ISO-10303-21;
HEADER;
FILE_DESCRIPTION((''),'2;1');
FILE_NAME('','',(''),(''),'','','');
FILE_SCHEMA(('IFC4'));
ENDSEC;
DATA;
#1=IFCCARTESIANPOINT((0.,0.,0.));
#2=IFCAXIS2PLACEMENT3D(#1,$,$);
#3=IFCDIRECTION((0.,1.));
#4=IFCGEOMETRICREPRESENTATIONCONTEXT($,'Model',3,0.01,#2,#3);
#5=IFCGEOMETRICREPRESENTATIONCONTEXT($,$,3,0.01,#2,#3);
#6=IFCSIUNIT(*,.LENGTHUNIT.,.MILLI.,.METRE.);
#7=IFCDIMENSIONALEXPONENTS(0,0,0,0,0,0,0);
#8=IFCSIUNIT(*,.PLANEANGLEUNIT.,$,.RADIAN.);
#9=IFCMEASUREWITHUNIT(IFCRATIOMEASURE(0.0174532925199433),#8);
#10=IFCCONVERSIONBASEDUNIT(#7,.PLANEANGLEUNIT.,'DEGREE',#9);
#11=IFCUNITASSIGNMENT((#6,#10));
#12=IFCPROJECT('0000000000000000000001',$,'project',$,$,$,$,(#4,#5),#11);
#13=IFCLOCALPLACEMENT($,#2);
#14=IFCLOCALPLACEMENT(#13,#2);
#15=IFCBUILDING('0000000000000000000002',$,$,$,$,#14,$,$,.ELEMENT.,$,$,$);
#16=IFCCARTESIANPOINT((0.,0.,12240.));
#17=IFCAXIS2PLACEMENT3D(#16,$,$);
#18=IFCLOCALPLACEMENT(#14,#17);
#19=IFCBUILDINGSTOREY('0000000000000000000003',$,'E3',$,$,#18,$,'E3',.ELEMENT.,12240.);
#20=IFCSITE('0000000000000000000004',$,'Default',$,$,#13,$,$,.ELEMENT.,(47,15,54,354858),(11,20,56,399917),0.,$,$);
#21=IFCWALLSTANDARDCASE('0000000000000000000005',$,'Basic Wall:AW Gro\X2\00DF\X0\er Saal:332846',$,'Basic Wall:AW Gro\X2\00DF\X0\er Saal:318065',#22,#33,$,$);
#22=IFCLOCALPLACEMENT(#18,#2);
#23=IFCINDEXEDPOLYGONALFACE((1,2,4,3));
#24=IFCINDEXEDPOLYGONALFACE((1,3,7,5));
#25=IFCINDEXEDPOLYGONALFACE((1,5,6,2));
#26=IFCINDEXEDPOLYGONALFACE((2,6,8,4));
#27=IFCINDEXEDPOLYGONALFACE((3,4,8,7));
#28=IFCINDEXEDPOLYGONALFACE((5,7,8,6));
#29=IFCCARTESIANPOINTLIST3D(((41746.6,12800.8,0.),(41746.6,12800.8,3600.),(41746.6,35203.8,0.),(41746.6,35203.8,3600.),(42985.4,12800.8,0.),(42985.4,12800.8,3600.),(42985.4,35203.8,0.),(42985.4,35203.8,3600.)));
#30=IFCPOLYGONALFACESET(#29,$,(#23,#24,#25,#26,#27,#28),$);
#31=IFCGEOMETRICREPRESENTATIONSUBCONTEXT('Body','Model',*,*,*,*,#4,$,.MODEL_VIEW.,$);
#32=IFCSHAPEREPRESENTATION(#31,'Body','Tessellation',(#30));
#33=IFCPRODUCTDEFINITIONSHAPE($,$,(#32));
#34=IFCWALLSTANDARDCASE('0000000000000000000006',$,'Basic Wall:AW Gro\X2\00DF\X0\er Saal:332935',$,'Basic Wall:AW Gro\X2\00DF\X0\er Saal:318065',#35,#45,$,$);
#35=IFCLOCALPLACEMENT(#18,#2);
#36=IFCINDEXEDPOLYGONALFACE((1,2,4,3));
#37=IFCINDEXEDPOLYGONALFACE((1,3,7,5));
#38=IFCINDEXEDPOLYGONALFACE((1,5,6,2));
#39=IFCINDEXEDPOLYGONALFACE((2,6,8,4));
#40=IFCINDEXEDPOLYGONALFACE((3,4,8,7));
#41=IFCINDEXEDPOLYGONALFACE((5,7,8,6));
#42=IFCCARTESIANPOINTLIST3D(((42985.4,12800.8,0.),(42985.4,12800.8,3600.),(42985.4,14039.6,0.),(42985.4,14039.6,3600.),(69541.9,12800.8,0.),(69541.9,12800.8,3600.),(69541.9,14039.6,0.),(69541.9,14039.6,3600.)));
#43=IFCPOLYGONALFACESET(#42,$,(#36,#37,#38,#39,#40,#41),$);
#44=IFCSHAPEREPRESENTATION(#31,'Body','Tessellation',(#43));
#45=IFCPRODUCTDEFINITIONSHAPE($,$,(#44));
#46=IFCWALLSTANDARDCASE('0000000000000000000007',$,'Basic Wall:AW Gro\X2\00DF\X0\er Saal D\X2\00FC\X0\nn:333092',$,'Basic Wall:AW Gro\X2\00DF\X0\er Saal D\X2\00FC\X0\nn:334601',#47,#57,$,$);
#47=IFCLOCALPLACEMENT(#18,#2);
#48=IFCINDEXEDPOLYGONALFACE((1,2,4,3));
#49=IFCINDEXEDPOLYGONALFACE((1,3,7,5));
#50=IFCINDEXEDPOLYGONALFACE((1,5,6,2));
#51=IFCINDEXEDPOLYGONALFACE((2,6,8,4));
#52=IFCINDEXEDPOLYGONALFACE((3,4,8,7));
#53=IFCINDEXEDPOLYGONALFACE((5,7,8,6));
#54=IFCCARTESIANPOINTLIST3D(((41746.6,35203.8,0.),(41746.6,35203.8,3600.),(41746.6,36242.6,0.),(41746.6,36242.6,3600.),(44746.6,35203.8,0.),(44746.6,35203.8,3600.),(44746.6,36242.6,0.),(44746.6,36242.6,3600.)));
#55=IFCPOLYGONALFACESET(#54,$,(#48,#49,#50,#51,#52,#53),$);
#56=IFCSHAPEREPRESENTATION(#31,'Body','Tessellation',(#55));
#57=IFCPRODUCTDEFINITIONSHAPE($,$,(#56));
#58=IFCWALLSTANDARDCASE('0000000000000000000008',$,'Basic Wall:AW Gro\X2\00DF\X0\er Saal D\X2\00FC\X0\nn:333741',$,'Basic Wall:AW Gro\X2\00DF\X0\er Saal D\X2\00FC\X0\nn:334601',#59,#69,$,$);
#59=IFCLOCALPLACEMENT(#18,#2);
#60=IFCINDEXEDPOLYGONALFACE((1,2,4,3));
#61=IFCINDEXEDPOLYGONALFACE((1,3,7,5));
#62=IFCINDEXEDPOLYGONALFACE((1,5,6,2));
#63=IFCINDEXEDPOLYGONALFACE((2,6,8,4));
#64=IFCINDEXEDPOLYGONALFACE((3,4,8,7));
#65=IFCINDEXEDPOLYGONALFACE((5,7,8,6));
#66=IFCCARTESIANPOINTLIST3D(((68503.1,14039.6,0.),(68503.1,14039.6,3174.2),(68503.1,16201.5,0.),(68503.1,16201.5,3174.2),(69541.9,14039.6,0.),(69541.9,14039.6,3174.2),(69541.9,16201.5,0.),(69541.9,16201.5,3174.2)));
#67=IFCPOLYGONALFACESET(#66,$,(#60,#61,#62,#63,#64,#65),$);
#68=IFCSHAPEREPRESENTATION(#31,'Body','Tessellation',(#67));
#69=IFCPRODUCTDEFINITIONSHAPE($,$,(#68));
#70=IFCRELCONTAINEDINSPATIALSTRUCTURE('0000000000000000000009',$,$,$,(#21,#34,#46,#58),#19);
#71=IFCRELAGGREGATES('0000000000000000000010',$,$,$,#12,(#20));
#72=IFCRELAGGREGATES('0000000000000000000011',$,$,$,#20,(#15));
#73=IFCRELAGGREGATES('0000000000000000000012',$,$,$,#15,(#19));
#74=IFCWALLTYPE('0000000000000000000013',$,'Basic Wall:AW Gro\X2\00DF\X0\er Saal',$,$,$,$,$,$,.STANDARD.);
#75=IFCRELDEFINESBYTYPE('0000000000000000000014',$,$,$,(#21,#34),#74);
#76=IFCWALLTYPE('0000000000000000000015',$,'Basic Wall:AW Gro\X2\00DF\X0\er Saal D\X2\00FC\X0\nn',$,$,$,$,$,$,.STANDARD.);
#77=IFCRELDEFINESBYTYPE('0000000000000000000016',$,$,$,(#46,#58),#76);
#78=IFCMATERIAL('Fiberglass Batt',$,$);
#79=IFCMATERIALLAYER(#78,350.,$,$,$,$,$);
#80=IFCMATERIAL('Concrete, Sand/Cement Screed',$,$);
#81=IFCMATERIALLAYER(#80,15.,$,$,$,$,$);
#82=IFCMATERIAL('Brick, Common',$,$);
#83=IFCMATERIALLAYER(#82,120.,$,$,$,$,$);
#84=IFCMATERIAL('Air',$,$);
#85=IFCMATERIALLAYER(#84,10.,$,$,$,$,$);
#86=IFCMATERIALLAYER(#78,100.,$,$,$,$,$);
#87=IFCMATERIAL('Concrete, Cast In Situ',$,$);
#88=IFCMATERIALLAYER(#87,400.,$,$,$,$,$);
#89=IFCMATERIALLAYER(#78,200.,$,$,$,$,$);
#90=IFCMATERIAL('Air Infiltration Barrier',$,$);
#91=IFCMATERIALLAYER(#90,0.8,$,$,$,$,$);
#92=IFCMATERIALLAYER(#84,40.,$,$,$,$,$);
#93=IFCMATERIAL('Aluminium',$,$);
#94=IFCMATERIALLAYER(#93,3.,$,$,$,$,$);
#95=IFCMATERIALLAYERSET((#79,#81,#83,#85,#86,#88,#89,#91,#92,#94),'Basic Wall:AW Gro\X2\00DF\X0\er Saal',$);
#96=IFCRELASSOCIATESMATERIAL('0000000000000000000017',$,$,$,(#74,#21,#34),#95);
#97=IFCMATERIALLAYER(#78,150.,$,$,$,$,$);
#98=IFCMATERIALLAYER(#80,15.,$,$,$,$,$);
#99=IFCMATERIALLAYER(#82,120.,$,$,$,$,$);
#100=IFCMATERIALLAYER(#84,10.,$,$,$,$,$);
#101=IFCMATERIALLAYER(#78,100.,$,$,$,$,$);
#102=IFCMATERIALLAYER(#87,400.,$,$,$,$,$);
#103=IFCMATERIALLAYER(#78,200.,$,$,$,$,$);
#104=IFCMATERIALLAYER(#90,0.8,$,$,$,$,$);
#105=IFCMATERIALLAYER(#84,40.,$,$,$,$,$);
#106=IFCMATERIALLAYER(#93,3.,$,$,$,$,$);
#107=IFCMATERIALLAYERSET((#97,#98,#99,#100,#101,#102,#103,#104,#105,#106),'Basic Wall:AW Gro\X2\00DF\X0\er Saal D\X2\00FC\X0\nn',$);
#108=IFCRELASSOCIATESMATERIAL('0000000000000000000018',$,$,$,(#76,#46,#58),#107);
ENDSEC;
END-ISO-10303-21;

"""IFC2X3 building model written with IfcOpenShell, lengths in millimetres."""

from ifc_helpers import new_model, entity, si_unit, converted_unit, direction, frame, frame_2d, origin, place, context, subcontext, project, spatial, polyline, rectangle, extrude, clip, bounded_halfspace, material, layer, layer_set, layer_usage, type_object, element, save


model = new_model("IFC2X3")

# Units and contexts
model_context = context("Model", 3, precision=0.01, world=origin(), true_north=direction((0.0, 1.0)))
context_of_model = context(None, 3, precision=0.01, world=origin(), true_north=direction((0.0, 1.0)))
body_context = subcontext(model_context, "Body", "Model", "MODEL_VIEW")
ifc_project = project(units=[si_unit("LENGTHUNIT", "METRE", prefix="MILLI"), converted_unit("PLANEANGLEUNIT", "DEGREE", entity("IfcRatioMeasure", 0.0174532925199433), si_unit("PLANEANGLEUNIT", "RADIAN"), dimensions=[0, 0, 0, 0, 0, 0, 0])], contexts=[model_context, context_of_model])

# Site, building, storey
site_placement = place(None, origin())
site = spatial("IfcSite", under=ifc_project, at=site_placement, Name="Default", CompositionType="ELEMENT", RefLatitude=(47, 15, 54, 354858), RefLongitude=(11, 20, 56, 399917), RefElevation=0.0)
building_placement = place(site_placement, origin())
building = spatial("IfcBuilding", under=site, at=building_placement, CompositionType="ELEMENT")
storey_placement = place(building_placement, frame((0.0, 0.0, 12240.0)))
storey = spatial("IfcBuildingStorey", under=building, at=storey_placement, Name="E3", LongName="E3", CompositionType="ELEMENT", Elevation=12240.0)

# Shared definitions
ifc_material_1 = material(Name="Concrete, Sand/Cement Screed")
ifc_material_2 = material(Name="Air Infiltration Barrier")
ifc_material_3 = material(Name="Fiberglass Batt")

# Shared definitions
ifc_material_4 = material(Name="Concrete, Cast In Situ")

# Shared definitions
ifc_material_5 = material(Name="Air")
ifc_material_6 = material(Name="Aluminium")

# Walls
ifc_material_7 = material(Name="Brick, Common")
ifc_layer_1 = layer(ifc_material_3, 350.0)
ifc_layer_2 = layer(ifc_material_1, 15.0)
ifc_layer_3 = layer(ifc_material_7, 120.0)
ifc_layer_4 = layer(ifc_material_5, 10.0)
ifc_layer_5 = layer(ifc_material_3, 100.0)
ifc_layer_6 = layer(ifc_material_4, 400.0)
ifc_layer_7 = layer(ifc_material_3, 200.0)
ifc_layer_8 = layer(ifc_material_2, 0.8)
ifc_layer_9 = layer(ifc_material_5, 40.0)
ifc_layer_10 = layer(ifc_material_6, 3.0)
ifc_layer_set_1 = layer_set([ifc_layer_1, ifc_layer_2, ifc_layer_3, ifc_layer_4, ifc_layer_5, ifc_layer_6, ifc_layer_7, ifc_layer_8, ifc_layer_9, ifc_layer_10], Name="Basic Wall:AW Großer Saal")
ifc_layer_usage_1 = layer_usage(ifc_layer_set_1, "AXIS2", "NEGATIVE", 619.4)
wall_type_1 = type_object("IfcWallType", Name="Basic Wall:AW Großer Saal", PredefinedType="STANDARD", material=ifc_layer_set_1)
wall_1_placement = place(storey_placement, frame((42366.0, 35203.8, 0.0), z_axis=(0.0, 0.0, 1.0), x_axis=(0.0, -1.0, 0.0)))
element("IfcWallStandardCase", 1, at=wall_1_placement, inside=storey, type_object=wall_type_1, material=ifc_layer_usage_1, Name="Basic Wall:AW Großer Saal:332846", ObjectType="Basic Wall:AW Großer Saal:318065", context=body_context, shape_type="SweptSolid", body=[
    extrude(rectangle(XDim=22402.9, YDim=1238.8, at=frame_2d((11201.5, 0.0), x_axis=(-1.0, 0.0))), origin(), (0.0, 0.0, 1.0), 3600.0),
])
ifc_layer_usage_2 = layer_usage(ifc_layer_set_1, "AXIS2", "NEGATIVE", 619.4)
wall_2_placement = place(storey_placement, frame((42985.4, 13420.2, 0.0)))
element("IfcWallStandardCase", 2, at=wall_2_placement, inside=storey, type_object=wall_type_1, material=ifc_layer_usage_2, Name="Basic Wall:AW Großer Saal:332935", ObjectType="Basic Wall:AW Großer Saal:318065", context=body_context, shape_type="SweptSolid", body=[
    extrude(rectangle(XDim=26556.5, YDim=1238.8, at=frame_2d((13278.3, 0.0), x_axis=(-1.0, 0.0))), origin(), (0.0, 0.0, 1.0), 3600.0),
])
ifc_layer_11 = layer(ifc_material_3, 150.0)
ifc_layer_12 = layer(ifc_material_1, 15.0)
ifc_layer_13 = layer(ifc_material_7, 120.0)
ifc_layer_14 = layer(ifc_material_5, 10.0)
ifc_layer_15 = layer(ifc_material_3, 100.0)
ifc_layer_16 = layer(ifc_material_4, 400.0)
ifc_layer_17 = layer(ifc_material_3, 200.0)
ifc_layer_18 = layer(ifc_material_2, 0.8)
ifc_layer_19 = layer(ifc_material_5, 40.0)
ifc_layer_20 = layer(ifc_material_6, 3.0)
ifc_layer_set_2 = layer_set([ifc_layer_11, ifc_layer_12, ifc_layer_13, ifc_layer_14, ifc_layer_15, ifc_layer_16, ifc_layer_17, ifc_layer_18, ifc_layer_19, ifc_layer_20], Name="Basic Wall:AW Großer Saal Dünn")
ifc_layer_usage_3 = layer_usage(ifc_layer_set_2, "AXIS2", "NEGATIVE", 519.4)
wall_type_2 = type_object("IfcWallType", Name="Basic Wall:AW Großer Saal Dünn", PredefinedType="STANDARD", material=ifc_layer_set_2)
wall_3_placement = place(storey_placement, frame((44746.6, 35723.2, 0.0), z_axis=(0.0, 0.0, 1.0), x_axis=(-1.0, 0.0, 0.0)))
element("IfcWallStandardCase", 3, at=wall_3_placement, inside=storey, type_object=wall_type_2, material=ifc_layer_usage_3, Name="Basic Wall:AW Großer Saal Dünn:333092", ObjectType="Basic Wall:AW Großer Saal Dünn:334601", context=body_context, shape_type="SweptSolid", body=[
    extrude(rectangle(XDim=3000.0, YDim=1038.8, at=frame_2d((1500.0, 0.0), x_axis=(-1.0, 0.0))), origin(), (0.0, 0.0, 1.0), 3600.0),
])
ifc_layer_usage_4 = layer_usage(ifc_layer_set_2, "AXIS2", "NEGATIVE", 519.4)
wall_4_placement = place(storey_placement, frame((69022.5, 14039.6, 0.0), z_axis=(0.0, 0.0, 1.0), x_axis=(0.0, 1.0, 0.0)))
element("IfcWallStandardCase", 4, at=wall_4_placement, inside=storey, type_object=wall_type_2, material=ifc_layer_usage_4, Name="Basic Wall:AW Großer Saal Dünn:333741", ObjectType="Basic Wall:AW Großer Saal Dünn:334601", context=body_context, shape_type="Clipping", body=[
    clip(extrude(rectangle(XDim=2161.9, YDim=1038.8, at=frame_2d((1081.0, 0.0), x_axis=(-1.0, 0.0))), origin(), (0.0, 0.0, 1.0), 3174.2), bounded_halfspace(frame((0.0, -519.4, 3174.2), z_axis=(0.0, 0.0, -1.0), x_axis=(-1.0, 0.0, 0.0)), True, frame((0.0, -519.4, 3174.2)), polyline([(0.0, 0.0), (1885.0, 0.0), (2161.9, 0.0), (2161.9, 390.3), (2161.9, 1035.3), (2161.9, 1038.8), (0.0, 1038.8), (0.0, 0.0)]))),
])

save(model, "model.ifc")
